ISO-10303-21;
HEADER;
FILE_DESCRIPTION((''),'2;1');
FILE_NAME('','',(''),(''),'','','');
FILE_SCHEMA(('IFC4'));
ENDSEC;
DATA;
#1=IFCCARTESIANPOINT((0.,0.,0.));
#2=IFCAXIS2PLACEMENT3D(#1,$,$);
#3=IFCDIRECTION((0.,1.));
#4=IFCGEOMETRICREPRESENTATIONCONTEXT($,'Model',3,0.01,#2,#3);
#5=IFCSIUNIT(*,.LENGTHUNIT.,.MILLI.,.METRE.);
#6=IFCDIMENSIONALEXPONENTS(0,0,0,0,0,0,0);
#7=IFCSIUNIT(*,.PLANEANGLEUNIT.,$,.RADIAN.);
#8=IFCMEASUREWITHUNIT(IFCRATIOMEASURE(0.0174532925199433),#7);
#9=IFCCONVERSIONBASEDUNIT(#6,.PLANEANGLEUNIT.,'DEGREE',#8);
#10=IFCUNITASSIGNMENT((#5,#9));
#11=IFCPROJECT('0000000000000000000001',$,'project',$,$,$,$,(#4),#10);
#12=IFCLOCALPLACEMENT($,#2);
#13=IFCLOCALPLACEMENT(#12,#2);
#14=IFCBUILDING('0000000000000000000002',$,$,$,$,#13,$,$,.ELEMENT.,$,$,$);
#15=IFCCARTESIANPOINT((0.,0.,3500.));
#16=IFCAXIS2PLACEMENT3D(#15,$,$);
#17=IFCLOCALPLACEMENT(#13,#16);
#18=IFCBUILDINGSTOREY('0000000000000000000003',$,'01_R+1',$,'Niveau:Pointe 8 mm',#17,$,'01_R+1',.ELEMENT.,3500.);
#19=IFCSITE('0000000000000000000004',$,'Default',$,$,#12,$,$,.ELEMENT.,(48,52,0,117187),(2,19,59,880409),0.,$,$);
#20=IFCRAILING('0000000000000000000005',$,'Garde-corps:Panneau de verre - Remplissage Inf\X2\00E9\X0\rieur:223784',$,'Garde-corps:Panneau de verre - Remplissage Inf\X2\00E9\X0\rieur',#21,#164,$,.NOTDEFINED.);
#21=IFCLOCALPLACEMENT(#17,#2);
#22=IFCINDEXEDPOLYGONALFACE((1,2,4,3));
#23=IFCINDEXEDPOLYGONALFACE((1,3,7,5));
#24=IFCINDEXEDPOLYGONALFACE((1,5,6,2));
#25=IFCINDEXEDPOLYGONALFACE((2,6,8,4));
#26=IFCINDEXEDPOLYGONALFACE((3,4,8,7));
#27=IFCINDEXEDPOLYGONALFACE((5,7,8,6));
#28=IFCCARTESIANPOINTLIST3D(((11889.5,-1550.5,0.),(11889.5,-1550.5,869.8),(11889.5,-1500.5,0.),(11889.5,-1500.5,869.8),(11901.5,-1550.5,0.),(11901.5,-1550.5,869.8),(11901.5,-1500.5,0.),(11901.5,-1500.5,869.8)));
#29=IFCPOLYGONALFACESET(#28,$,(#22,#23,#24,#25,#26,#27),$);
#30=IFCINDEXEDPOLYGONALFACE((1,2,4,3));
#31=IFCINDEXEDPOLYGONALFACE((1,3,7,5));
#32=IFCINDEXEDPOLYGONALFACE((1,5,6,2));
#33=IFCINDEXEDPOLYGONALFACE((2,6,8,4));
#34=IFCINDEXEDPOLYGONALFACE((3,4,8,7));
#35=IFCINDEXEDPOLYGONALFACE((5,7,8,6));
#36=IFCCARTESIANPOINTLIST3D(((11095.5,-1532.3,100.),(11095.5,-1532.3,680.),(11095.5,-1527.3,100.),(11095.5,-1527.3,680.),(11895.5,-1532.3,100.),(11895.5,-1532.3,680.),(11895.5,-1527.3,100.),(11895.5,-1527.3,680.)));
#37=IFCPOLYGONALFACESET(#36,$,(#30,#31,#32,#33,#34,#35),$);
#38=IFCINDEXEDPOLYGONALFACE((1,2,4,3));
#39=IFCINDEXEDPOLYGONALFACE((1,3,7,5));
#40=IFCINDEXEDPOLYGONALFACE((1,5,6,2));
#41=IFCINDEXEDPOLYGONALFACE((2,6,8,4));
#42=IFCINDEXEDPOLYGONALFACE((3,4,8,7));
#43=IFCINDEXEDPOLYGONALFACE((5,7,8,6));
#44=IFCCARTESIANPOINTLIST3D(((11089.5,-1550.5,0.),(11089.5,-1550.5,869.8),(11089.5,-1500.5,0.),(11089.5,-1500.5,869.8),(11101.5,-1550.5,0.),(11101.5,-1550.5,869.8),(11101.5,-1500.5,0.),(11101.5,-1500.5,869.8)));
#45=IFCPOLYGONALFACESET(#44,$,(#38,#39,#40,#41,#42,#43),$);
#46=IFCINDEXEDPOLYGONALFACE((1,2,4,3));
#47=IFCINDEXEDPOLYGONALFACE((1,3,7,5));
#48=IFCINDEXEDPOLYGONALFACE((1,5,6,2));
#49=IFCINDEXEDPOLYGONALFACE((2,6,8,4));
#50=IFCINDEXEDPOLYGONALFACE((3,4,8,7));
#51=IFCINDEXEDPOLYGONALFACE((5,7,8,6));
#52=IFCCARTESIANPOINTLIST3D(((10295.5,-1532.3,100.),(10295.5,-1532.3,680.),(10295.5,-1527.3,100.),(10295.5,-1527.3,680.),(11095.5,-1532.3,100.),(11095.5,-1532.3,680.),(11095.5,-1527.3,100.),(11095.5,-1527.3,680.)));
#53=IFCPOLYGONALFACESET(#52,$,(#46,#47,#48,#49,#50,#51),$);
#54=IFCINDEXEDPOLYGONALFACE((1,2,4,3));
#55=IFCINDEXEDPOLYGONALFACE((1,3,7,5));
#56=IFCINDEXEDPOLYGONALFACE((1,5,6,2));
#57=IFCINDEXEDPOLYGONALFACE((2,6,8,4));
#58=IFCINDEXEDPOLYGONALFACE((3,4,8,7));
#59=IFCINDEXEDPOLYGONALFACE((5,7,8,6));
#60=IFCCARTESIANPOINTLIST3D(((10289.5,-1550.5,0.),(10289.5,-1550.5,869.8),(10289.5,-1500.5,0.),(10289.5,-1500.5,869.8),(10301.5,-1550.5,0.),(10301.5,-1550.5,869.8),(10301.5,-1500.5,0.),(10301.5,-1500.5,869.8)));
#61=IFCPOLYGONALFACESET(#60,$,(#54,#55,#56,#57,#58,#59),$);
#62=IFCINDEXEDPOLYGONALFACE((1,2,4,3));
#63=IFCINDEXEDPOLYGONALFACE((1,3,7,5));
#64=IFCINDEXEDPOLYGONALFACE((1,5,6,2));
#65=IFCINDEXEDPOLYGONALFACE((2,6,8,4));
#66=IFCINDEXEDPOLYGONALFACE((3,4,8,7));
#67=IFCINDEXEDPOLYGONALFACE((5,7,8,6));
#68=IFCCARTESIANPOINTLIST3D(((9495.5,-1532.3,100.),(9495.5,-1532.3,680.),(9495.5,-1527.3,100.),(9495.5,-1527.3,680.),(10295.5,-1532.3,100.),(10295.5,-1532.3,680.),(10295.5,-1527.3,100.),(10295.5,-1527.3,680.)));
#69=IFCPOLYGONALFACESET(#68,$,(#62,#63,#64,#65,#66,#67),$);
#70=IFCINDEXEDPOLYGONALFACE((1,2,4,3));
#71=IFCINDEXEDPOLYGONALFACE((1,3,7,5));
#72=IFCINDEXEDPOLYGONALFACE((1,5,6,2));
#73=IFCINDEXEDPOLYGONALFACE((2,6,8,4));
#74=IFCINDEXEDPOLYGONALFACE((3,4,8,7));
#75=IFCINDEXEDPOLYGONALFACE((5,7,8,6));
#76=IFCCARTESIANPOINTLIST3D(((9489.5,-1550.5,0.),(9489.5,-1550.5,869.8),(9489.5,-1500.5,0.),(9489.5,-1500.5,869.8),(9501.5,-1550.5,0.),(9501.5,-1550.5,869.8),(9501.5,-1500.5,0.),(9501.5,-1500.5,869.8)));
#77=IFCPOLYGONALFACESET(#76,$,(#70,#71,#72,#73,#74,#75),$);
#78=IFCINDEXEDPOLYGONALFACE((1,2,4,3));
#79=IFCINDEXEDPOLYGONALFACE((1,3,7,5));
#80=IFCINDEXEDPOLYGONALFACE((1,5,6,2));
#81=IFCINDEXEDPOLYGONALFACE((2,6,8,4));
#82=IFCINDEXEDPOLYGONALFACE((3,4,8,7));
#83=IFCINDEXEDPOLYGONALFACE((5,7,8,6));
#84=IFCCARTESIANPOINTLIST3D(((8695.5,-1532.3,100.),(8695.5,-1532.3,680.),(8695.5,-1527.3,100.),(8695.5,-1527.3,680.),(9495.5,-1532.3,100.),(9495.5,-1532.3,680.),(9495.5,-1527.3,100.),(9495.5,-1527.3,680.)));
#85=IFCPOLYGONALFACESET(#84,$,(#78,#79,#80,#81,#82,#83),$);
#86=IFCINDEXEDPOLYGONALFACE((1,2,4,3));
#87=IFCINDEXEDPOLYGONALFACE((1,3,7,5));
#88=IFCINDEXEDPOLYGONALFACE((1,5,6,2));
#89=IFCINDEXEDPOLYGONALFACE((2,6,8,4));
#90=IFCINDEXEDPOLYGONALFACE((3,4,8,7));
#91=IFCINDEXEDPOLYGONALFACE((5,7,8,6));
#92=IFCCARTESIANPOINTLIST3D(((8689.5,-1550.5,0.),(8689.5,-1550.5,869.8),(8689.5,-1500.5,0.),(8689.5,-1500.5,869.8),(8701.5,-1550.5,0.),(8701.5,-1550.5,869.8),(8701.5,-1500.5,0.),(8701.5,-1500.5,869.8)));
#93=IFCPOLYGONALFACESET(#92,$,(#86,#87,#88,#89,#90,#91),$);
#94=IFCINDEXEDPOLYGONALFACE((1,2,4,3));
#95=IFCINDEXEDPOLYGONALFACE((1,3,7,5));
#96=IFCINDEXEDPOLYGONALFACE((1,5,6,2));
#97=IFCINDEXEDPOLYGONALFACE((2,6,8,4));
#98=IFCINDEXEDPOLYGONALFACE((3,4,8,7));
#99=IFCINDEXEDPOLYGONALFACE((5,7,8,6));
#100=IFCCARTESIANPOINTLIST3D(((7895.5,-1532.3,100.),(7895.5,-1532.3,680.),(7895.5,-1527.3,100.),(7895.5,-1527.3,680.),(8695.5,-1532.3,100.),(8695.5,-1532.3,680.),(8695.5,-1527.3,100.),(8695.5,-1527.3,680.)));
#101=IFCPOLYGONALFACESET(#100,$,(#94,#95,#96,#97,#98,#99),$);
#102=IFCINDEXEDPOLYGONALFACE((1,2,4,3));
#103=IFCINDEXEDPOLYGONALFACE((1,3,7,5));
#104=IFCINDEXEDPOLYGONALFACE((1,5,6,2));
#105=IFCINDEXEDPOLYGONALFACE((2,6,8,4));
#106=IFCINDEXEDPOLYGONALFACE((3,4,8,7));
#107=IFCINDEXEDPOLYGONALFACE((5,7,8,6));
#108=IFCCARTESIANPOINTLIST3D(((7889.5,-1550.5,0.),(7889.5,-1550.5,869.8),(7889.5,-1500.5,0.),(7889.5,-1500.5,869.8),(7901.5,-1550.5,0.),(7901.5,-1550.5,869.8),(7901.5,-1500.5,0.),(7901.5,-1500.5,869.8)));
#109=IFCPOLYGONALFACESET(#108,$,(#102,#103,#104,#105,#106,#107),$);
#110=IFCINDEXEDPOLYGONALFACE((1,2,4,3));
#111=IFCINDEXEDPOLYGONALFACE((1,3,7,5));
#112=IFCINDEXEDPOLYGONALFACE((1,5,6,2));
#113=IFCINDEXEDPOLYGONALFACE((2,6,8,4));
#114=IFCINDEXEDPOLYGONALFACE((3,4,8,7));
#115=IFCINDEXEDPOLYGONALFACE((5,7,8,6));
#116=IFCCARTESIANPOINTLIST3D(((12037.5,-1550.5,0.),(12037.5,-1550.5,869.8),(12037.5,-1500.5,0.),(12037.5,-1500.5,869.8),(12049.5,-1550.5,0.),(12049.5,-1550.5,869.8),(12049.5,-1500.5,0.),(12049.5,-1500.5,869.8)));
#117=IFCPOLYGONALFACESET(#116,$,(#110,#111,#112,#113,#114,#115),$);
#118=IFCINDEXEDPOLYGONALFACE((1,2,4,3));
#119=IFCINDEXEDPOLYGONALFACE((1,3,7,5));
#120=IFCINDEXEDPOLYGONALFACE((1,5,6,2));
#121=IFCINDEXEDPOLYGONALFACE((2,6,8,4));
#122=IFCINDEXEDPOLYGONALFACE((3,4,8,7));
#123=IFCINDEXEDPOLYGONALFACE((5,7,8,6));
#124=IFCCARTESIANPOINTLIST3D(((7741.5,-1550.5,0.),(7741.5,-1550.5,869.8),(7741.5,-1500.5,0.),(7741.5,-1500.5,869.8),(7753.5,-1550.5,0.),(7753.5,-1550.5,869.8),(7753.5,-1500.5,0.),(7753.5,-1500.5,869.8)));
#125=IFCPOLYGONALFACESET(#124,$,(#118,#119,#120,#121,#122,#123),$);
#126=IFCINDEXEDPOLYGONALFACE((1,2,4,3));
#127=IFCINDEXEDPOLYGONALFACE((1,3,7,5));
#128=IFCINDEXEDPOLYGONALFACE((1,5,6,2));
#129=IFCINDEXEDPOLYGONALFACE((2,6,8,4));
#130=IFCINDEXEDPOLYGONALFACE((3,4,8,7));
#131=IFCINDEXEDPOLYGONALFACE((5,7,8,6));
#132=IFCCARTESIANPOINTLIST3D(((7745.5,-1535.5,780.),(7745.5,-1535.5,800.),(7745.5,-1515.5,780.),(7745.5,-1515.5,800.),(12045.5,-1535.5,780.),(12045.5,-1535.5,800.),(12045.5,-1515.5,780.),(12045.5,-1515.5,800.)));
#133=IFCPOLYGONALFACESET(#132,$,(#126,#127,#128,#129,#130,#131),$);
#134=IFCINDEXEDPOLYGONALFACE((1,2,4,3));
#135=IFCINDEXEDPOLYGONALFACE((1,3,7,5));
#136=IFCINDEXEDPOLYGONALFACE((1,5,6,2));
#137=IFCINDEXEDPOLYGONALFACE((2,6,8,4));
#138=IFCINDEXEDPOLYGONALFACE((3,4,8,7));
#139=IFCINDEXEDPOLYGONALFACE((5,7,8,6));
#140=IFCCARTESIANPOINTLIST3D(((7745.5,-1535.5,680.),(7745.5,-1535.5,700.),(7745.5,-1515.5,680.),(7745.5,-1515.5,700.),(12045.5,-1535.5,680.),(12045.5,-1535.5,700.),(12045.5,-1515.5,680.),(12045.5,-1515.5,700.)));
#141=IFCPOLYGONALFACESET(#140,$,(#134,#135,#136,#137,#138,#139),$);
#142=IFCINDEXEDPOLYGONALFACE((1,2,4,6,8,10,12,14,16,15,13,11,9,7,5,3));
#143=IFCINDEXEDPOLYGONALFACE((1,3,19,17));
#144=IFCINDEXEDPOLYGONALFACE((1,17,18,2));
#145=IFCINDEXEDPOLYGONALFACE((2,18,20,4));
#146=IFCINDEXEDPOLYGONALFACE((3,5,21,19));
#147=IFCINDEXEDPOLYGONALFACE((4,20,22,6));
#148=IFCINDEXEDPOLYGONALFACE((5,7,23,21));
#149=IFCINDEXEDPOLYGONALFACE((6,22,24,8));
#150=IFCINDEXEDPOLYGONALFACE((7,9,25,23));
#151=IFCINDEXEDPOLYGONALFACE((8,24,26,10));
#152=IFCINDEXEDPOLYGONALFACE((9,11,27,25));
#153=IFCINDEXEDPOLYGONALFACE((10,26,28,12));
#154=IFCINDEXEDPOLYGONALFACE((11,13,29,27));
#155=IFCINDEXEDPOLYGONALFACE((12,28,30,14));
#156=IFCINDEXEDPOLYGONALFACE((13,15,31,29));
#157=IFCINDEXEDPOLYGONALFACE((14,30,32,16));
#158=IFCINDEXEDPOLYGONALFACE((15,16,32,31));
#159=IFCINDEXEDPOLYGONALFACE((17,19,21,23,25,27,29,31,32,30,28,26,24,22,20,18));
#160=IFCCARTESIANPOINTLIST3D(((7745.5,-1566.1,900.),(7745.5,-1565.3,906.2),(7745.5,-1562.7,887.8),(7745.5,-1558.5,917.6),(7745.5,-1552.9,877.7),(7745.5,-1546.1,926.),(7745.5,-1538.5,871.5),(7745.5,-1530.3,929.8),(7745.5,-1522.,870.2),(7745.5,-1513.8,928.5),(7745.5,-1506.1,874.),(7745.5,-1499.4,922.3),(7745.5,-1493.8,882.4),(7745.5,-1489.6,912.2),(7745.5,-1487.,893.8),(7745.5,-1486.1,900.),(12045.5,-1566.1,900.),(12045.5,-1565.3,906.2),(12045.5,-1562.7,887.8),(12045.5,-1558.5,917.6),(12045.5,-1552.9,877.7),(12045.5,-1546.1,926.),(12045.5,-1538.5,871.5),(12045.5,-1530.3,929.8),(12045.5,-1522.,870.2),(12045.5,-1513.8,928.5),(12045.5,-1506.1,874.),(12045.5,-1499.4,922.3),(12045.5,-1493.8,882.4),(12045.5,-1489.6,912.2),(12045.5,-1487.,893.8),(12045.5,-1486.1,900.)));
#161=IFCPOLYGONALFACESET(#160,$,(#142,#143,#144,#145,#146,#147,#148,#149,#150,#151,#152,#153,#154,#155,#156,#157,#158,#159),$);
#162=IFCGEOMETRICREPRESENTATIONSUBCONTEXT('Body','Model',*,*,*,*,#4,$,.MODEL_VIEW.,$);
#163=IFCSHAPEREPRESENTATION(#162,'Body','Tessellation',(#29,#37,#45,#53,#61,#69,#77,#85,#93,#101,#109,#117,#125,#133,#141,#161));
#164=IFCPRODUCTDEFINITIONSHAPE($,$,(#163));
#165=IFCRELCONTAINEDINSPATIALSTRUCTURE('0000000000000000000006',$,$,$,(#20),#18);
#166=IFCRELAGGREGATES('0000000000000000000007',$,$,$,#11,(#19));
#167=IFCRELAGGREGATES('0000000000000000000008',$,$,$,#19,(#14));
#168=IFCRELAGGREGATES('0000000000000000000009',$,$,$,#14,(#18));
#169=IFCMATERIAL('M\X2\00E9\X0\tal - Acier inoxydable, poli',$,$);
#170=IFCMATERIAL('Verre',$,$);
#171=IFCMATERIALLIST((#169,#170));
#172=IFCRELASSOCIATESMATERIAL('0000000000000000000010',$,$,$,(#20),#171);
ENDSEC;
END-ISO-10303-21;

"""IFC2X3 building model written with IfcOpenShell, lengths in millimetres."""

from ifc_helpers import new_model, entity, si_unit, converted_unit, direction, frame, frame_2d, origin, origin_2d_with_axis, place, context, subcontext, project, spatial, polyline, rectangle, outline, extrude, material, material_list, element, save


model = new_model("IFC2X3")

# Units and contexts
model_context = context("Model", 3, precision=0.01, world=origin(), true_north=direction((0.0, 1.0)))
body_context = subcontext(model_context, "Body", "Model", "MODEL_VIEW")
ifc_project = project(units=[si_unit("LENGTHUNIT", "METRE", prefix="MILLI"), converted_unit("PLANEANGLEUNIT", "DEGREE", entity("IfcRatioMeasure", 0.0174532925199433), si_unit("PLANEANGLEUNIT", "RADIAN"), dimensions=[0, 0, 0, 0, 0, 0, 0])], contexts=[model_context])

# Site, building, storey
site_placement = place(None, origin())
site = spatial("IfcSite", under=ifc_project, at=site_placement, Name="Default", CompositionType="ELEMENT", RefLatitude=(48, 52, 0, 117187), RefLongitude=(2, 19, 59, 880409), RefElevation=0.0)
building_placement = place(site_placement, origin())
building = spatial("IfcBuilding", under=site, at=building_placement, CompositionType="ELEMENT")
storey_placement = place(building_placement, frame((0.0, 0.0, 3500.0)))
storey = spatial("IfcBuildingStorey", under=building, at=storey_placement, Name="01_R+1", ObjectType="Niveau:Pointe 8 mm", LongName="01_R+1", CompositionType="ELEMENT", Elevation=3500.0)

# Railing
ifc_material_1 = material(Name="Métal - Acier inoxydable, poli")
ifc_material_2 = material(Name="Verre")
ifc_material_list_1 = material_list([ifc_material_1, ifc_material_2])
railing_1_placement = place(storey_placement, origin())
element("IfcRailing", 1, at=railing_1_placement, inside=storey, material=ifc_material_list_1, Name="Garde-corps:Panneau de verre - Remplissage Inférieur:223784", ObjectType="Garde-corps:Panneau de verre - Remplissage Inférieur", PredefinedType="NOTDEFINED", context=body_context, shape_type="SweptSolid", body=[
    extrude(rectangle(XDim=50.0, YDim=12.0, at=frame_2d((0.0, 0.0), x_axis=(1.0, 0.0))), frame((11895.5, -1525.5, 0.0), z_axis=(0.0, 0.0, 1.0), x_axis=(0.0, -1.0, 0.0)), (0.0, 0.0, 1.0), 869.8),
    extrude(rectangle(XDim=5.0, YDim=800.0, at=frame_2d((0.0, 0.0), x_axis=(1.0, 0.0))), frame((11495.5, -1529.8, 100.0), z_axis=(0.0, 0.0, 1.0), x_axis=(0.0, -1.0, 0.0)), (0.0, 0.0, 1.0), 580.0),
    extrude(rectangle(XDim=50.0, YDim=12.0, at=frame_2d((0.0, 0.0), x_axis=(1.0, 0.0))), frame((11095.5, -1525.5, 0.0), z_axis=(0.0, 0.0, 1.0), x_axis=(0.0, -1.0, 0.0)), (0.0, 0.0, 1.0), 869.8),
    extrude(rectangle(XDim=5.0, YDim=800.0, at=frame_2d((0.0, 0.0), x_axis=(1.0, 0.0))), frame((10695.5, -1529.8, 100.0), z_axis=(0.0, 0.0, 1.0), x_axis=(0.0, -1.0, 0.0)), (0.0, 0.0, 1.0), 580.0),
    extrude(rectangle(XDim=50.0, YDim=12.0, at=frame_2d((0.0, 0.0), x_axis=(1.0, 0.0))), frame((10295.5, -1525.5, 0.0), z_axis=(0.0, 0.0, 1.0), x_axis=(0.0, -1.0, 0.0)), (0.0, 0.0, 1.0), 869.8),
    extrude(rectangle(XDim=5.0, YDim=800.0, at=frame_2d((0.0, 0.0), x_axis=(1.0, 0.0))), frame((9895.5, -1529.8, 100.0), z_axis=(0.0, 0.0, 1.0), x_axis=(0.0, -1.0, 0.0)), (0.0, 0.0, 1.0), 580.0),
    extrude(rectangle(XDim=50.0, YDim=12.0, at=frame_2d((0.0, 0.0), x_axis=(1.0, 0.0))), frame((9495.5, -1525.5, 0.0), z_axis=(0.0, 0.0, 1.0), x_axis=(0.0, -1.0, 0.0)), (0.0, 0.0, 1.0), 869.8),
    extrude(rectangle(XDim=5.0, YDim=800.0, at=origin_2d_with_axis()), frame((9095.5, -1529.8, 100.0), z_axis=(0.0, 0.0, 1.0), x_axis=(0.0, -1.0, 0.0)), (0.0, 0.0, 1.0), 580.0),
    extrude(rectangle(XDim=50.0, YDim=12.0, at=frame_2d((0.0, 0.0), x_axis=(1.0, 0.0))), frame((8695.5, -1525.5, 0.0), z_axis=(0.0, 0.0, 1.0), x_axis=(0.0, -1.0, 0.0)), (0.0, 0.0, 1.0), 869.8),
    extrude(rectangle(XDim=5.0, YDim=800.0, at=origin_2d_with_axis()), frame((8295.5, -1529.8, 100.0), z_axis=(0.0, 0.0, 1.0), x_axis=(0.0, -1.0, 0.0)), (0.0, 0.0, 1.0), 580.0),
    extrude(rectangle(XDim=50.0, YDim=12.0, at=frame_2d((0.0, 0.0), x_axis=(1.0, 0.0))), frame((7895.5, -1525.5, 0.0), z_axis=(0.0, 0.0, 1.0), x_axis=(0.0, -1.0, 0.0)), (0.0, 0.0, 1.0), 869.8),
    extrude(rectangle(XDim=50.0, YDim=12.0, at=frame_2d((0.0, 0.0), x_axis=(1.0, 0.0))), frame((12043.5, -1525.5, 0.0), z_axis=(0.0, 0.0, 1.0), x_axis=(0.0, -1.0, 0.0)), (0.0, 0.0, 1.0), 869.8),
    extrude(rectangle(XDim=50.0, YDim=12.0, at=frame_2d((0.0, 0.0), x_axis=(1.0, 0.0))), frame((7747.5, -1525.5, 0.0), z_axis=(0.0, 0.0, 1.0), x_axis=(0.0, -1.0, 0.0)), (0.0, 0.0, 1.0), 869.8),
    extrude(rectangle(XDim=4300.0, YDim=20.0, at=origin_2d_with_axis()), frame((9895.5, -1525.5, 780.0)), (0.0, 0.0, 1.0), 20.0),
    extrude(rectangle(XDim=4300.0, YDim=20.0, at=origin_2d_with_axis()), frame((9895.5, -1525.5, 680.0)), (0.0, 0.0, 1.0), 20.0),
    extrude(outline(polyline([(-10.9, -38.5), (1.8, -38.5), (14.2, -31.8), (24.1, -19.7), (29.8, -4.1), (30.4, 12.2), (25.8, 26.3), (16.7, 35.9), (10.9, 38.5), (-1.8, 38.5), (-14.2, 31.8), (-24.1, 19.7), (-29.8, 4.1), (-30.4, -12.2), (-25.8, -26.3), (-16.7, -35.9), (-10.9, -38.5)])), frame((7745.5, -1526.1, 900.0), z_axis=(1.0, 0.0, 0.0), x_axis=(0.0, 0.27267, -0.962108)), (0.0, 0.0, 1.0), 4300.0),
])

save(model, "model.ifc")
